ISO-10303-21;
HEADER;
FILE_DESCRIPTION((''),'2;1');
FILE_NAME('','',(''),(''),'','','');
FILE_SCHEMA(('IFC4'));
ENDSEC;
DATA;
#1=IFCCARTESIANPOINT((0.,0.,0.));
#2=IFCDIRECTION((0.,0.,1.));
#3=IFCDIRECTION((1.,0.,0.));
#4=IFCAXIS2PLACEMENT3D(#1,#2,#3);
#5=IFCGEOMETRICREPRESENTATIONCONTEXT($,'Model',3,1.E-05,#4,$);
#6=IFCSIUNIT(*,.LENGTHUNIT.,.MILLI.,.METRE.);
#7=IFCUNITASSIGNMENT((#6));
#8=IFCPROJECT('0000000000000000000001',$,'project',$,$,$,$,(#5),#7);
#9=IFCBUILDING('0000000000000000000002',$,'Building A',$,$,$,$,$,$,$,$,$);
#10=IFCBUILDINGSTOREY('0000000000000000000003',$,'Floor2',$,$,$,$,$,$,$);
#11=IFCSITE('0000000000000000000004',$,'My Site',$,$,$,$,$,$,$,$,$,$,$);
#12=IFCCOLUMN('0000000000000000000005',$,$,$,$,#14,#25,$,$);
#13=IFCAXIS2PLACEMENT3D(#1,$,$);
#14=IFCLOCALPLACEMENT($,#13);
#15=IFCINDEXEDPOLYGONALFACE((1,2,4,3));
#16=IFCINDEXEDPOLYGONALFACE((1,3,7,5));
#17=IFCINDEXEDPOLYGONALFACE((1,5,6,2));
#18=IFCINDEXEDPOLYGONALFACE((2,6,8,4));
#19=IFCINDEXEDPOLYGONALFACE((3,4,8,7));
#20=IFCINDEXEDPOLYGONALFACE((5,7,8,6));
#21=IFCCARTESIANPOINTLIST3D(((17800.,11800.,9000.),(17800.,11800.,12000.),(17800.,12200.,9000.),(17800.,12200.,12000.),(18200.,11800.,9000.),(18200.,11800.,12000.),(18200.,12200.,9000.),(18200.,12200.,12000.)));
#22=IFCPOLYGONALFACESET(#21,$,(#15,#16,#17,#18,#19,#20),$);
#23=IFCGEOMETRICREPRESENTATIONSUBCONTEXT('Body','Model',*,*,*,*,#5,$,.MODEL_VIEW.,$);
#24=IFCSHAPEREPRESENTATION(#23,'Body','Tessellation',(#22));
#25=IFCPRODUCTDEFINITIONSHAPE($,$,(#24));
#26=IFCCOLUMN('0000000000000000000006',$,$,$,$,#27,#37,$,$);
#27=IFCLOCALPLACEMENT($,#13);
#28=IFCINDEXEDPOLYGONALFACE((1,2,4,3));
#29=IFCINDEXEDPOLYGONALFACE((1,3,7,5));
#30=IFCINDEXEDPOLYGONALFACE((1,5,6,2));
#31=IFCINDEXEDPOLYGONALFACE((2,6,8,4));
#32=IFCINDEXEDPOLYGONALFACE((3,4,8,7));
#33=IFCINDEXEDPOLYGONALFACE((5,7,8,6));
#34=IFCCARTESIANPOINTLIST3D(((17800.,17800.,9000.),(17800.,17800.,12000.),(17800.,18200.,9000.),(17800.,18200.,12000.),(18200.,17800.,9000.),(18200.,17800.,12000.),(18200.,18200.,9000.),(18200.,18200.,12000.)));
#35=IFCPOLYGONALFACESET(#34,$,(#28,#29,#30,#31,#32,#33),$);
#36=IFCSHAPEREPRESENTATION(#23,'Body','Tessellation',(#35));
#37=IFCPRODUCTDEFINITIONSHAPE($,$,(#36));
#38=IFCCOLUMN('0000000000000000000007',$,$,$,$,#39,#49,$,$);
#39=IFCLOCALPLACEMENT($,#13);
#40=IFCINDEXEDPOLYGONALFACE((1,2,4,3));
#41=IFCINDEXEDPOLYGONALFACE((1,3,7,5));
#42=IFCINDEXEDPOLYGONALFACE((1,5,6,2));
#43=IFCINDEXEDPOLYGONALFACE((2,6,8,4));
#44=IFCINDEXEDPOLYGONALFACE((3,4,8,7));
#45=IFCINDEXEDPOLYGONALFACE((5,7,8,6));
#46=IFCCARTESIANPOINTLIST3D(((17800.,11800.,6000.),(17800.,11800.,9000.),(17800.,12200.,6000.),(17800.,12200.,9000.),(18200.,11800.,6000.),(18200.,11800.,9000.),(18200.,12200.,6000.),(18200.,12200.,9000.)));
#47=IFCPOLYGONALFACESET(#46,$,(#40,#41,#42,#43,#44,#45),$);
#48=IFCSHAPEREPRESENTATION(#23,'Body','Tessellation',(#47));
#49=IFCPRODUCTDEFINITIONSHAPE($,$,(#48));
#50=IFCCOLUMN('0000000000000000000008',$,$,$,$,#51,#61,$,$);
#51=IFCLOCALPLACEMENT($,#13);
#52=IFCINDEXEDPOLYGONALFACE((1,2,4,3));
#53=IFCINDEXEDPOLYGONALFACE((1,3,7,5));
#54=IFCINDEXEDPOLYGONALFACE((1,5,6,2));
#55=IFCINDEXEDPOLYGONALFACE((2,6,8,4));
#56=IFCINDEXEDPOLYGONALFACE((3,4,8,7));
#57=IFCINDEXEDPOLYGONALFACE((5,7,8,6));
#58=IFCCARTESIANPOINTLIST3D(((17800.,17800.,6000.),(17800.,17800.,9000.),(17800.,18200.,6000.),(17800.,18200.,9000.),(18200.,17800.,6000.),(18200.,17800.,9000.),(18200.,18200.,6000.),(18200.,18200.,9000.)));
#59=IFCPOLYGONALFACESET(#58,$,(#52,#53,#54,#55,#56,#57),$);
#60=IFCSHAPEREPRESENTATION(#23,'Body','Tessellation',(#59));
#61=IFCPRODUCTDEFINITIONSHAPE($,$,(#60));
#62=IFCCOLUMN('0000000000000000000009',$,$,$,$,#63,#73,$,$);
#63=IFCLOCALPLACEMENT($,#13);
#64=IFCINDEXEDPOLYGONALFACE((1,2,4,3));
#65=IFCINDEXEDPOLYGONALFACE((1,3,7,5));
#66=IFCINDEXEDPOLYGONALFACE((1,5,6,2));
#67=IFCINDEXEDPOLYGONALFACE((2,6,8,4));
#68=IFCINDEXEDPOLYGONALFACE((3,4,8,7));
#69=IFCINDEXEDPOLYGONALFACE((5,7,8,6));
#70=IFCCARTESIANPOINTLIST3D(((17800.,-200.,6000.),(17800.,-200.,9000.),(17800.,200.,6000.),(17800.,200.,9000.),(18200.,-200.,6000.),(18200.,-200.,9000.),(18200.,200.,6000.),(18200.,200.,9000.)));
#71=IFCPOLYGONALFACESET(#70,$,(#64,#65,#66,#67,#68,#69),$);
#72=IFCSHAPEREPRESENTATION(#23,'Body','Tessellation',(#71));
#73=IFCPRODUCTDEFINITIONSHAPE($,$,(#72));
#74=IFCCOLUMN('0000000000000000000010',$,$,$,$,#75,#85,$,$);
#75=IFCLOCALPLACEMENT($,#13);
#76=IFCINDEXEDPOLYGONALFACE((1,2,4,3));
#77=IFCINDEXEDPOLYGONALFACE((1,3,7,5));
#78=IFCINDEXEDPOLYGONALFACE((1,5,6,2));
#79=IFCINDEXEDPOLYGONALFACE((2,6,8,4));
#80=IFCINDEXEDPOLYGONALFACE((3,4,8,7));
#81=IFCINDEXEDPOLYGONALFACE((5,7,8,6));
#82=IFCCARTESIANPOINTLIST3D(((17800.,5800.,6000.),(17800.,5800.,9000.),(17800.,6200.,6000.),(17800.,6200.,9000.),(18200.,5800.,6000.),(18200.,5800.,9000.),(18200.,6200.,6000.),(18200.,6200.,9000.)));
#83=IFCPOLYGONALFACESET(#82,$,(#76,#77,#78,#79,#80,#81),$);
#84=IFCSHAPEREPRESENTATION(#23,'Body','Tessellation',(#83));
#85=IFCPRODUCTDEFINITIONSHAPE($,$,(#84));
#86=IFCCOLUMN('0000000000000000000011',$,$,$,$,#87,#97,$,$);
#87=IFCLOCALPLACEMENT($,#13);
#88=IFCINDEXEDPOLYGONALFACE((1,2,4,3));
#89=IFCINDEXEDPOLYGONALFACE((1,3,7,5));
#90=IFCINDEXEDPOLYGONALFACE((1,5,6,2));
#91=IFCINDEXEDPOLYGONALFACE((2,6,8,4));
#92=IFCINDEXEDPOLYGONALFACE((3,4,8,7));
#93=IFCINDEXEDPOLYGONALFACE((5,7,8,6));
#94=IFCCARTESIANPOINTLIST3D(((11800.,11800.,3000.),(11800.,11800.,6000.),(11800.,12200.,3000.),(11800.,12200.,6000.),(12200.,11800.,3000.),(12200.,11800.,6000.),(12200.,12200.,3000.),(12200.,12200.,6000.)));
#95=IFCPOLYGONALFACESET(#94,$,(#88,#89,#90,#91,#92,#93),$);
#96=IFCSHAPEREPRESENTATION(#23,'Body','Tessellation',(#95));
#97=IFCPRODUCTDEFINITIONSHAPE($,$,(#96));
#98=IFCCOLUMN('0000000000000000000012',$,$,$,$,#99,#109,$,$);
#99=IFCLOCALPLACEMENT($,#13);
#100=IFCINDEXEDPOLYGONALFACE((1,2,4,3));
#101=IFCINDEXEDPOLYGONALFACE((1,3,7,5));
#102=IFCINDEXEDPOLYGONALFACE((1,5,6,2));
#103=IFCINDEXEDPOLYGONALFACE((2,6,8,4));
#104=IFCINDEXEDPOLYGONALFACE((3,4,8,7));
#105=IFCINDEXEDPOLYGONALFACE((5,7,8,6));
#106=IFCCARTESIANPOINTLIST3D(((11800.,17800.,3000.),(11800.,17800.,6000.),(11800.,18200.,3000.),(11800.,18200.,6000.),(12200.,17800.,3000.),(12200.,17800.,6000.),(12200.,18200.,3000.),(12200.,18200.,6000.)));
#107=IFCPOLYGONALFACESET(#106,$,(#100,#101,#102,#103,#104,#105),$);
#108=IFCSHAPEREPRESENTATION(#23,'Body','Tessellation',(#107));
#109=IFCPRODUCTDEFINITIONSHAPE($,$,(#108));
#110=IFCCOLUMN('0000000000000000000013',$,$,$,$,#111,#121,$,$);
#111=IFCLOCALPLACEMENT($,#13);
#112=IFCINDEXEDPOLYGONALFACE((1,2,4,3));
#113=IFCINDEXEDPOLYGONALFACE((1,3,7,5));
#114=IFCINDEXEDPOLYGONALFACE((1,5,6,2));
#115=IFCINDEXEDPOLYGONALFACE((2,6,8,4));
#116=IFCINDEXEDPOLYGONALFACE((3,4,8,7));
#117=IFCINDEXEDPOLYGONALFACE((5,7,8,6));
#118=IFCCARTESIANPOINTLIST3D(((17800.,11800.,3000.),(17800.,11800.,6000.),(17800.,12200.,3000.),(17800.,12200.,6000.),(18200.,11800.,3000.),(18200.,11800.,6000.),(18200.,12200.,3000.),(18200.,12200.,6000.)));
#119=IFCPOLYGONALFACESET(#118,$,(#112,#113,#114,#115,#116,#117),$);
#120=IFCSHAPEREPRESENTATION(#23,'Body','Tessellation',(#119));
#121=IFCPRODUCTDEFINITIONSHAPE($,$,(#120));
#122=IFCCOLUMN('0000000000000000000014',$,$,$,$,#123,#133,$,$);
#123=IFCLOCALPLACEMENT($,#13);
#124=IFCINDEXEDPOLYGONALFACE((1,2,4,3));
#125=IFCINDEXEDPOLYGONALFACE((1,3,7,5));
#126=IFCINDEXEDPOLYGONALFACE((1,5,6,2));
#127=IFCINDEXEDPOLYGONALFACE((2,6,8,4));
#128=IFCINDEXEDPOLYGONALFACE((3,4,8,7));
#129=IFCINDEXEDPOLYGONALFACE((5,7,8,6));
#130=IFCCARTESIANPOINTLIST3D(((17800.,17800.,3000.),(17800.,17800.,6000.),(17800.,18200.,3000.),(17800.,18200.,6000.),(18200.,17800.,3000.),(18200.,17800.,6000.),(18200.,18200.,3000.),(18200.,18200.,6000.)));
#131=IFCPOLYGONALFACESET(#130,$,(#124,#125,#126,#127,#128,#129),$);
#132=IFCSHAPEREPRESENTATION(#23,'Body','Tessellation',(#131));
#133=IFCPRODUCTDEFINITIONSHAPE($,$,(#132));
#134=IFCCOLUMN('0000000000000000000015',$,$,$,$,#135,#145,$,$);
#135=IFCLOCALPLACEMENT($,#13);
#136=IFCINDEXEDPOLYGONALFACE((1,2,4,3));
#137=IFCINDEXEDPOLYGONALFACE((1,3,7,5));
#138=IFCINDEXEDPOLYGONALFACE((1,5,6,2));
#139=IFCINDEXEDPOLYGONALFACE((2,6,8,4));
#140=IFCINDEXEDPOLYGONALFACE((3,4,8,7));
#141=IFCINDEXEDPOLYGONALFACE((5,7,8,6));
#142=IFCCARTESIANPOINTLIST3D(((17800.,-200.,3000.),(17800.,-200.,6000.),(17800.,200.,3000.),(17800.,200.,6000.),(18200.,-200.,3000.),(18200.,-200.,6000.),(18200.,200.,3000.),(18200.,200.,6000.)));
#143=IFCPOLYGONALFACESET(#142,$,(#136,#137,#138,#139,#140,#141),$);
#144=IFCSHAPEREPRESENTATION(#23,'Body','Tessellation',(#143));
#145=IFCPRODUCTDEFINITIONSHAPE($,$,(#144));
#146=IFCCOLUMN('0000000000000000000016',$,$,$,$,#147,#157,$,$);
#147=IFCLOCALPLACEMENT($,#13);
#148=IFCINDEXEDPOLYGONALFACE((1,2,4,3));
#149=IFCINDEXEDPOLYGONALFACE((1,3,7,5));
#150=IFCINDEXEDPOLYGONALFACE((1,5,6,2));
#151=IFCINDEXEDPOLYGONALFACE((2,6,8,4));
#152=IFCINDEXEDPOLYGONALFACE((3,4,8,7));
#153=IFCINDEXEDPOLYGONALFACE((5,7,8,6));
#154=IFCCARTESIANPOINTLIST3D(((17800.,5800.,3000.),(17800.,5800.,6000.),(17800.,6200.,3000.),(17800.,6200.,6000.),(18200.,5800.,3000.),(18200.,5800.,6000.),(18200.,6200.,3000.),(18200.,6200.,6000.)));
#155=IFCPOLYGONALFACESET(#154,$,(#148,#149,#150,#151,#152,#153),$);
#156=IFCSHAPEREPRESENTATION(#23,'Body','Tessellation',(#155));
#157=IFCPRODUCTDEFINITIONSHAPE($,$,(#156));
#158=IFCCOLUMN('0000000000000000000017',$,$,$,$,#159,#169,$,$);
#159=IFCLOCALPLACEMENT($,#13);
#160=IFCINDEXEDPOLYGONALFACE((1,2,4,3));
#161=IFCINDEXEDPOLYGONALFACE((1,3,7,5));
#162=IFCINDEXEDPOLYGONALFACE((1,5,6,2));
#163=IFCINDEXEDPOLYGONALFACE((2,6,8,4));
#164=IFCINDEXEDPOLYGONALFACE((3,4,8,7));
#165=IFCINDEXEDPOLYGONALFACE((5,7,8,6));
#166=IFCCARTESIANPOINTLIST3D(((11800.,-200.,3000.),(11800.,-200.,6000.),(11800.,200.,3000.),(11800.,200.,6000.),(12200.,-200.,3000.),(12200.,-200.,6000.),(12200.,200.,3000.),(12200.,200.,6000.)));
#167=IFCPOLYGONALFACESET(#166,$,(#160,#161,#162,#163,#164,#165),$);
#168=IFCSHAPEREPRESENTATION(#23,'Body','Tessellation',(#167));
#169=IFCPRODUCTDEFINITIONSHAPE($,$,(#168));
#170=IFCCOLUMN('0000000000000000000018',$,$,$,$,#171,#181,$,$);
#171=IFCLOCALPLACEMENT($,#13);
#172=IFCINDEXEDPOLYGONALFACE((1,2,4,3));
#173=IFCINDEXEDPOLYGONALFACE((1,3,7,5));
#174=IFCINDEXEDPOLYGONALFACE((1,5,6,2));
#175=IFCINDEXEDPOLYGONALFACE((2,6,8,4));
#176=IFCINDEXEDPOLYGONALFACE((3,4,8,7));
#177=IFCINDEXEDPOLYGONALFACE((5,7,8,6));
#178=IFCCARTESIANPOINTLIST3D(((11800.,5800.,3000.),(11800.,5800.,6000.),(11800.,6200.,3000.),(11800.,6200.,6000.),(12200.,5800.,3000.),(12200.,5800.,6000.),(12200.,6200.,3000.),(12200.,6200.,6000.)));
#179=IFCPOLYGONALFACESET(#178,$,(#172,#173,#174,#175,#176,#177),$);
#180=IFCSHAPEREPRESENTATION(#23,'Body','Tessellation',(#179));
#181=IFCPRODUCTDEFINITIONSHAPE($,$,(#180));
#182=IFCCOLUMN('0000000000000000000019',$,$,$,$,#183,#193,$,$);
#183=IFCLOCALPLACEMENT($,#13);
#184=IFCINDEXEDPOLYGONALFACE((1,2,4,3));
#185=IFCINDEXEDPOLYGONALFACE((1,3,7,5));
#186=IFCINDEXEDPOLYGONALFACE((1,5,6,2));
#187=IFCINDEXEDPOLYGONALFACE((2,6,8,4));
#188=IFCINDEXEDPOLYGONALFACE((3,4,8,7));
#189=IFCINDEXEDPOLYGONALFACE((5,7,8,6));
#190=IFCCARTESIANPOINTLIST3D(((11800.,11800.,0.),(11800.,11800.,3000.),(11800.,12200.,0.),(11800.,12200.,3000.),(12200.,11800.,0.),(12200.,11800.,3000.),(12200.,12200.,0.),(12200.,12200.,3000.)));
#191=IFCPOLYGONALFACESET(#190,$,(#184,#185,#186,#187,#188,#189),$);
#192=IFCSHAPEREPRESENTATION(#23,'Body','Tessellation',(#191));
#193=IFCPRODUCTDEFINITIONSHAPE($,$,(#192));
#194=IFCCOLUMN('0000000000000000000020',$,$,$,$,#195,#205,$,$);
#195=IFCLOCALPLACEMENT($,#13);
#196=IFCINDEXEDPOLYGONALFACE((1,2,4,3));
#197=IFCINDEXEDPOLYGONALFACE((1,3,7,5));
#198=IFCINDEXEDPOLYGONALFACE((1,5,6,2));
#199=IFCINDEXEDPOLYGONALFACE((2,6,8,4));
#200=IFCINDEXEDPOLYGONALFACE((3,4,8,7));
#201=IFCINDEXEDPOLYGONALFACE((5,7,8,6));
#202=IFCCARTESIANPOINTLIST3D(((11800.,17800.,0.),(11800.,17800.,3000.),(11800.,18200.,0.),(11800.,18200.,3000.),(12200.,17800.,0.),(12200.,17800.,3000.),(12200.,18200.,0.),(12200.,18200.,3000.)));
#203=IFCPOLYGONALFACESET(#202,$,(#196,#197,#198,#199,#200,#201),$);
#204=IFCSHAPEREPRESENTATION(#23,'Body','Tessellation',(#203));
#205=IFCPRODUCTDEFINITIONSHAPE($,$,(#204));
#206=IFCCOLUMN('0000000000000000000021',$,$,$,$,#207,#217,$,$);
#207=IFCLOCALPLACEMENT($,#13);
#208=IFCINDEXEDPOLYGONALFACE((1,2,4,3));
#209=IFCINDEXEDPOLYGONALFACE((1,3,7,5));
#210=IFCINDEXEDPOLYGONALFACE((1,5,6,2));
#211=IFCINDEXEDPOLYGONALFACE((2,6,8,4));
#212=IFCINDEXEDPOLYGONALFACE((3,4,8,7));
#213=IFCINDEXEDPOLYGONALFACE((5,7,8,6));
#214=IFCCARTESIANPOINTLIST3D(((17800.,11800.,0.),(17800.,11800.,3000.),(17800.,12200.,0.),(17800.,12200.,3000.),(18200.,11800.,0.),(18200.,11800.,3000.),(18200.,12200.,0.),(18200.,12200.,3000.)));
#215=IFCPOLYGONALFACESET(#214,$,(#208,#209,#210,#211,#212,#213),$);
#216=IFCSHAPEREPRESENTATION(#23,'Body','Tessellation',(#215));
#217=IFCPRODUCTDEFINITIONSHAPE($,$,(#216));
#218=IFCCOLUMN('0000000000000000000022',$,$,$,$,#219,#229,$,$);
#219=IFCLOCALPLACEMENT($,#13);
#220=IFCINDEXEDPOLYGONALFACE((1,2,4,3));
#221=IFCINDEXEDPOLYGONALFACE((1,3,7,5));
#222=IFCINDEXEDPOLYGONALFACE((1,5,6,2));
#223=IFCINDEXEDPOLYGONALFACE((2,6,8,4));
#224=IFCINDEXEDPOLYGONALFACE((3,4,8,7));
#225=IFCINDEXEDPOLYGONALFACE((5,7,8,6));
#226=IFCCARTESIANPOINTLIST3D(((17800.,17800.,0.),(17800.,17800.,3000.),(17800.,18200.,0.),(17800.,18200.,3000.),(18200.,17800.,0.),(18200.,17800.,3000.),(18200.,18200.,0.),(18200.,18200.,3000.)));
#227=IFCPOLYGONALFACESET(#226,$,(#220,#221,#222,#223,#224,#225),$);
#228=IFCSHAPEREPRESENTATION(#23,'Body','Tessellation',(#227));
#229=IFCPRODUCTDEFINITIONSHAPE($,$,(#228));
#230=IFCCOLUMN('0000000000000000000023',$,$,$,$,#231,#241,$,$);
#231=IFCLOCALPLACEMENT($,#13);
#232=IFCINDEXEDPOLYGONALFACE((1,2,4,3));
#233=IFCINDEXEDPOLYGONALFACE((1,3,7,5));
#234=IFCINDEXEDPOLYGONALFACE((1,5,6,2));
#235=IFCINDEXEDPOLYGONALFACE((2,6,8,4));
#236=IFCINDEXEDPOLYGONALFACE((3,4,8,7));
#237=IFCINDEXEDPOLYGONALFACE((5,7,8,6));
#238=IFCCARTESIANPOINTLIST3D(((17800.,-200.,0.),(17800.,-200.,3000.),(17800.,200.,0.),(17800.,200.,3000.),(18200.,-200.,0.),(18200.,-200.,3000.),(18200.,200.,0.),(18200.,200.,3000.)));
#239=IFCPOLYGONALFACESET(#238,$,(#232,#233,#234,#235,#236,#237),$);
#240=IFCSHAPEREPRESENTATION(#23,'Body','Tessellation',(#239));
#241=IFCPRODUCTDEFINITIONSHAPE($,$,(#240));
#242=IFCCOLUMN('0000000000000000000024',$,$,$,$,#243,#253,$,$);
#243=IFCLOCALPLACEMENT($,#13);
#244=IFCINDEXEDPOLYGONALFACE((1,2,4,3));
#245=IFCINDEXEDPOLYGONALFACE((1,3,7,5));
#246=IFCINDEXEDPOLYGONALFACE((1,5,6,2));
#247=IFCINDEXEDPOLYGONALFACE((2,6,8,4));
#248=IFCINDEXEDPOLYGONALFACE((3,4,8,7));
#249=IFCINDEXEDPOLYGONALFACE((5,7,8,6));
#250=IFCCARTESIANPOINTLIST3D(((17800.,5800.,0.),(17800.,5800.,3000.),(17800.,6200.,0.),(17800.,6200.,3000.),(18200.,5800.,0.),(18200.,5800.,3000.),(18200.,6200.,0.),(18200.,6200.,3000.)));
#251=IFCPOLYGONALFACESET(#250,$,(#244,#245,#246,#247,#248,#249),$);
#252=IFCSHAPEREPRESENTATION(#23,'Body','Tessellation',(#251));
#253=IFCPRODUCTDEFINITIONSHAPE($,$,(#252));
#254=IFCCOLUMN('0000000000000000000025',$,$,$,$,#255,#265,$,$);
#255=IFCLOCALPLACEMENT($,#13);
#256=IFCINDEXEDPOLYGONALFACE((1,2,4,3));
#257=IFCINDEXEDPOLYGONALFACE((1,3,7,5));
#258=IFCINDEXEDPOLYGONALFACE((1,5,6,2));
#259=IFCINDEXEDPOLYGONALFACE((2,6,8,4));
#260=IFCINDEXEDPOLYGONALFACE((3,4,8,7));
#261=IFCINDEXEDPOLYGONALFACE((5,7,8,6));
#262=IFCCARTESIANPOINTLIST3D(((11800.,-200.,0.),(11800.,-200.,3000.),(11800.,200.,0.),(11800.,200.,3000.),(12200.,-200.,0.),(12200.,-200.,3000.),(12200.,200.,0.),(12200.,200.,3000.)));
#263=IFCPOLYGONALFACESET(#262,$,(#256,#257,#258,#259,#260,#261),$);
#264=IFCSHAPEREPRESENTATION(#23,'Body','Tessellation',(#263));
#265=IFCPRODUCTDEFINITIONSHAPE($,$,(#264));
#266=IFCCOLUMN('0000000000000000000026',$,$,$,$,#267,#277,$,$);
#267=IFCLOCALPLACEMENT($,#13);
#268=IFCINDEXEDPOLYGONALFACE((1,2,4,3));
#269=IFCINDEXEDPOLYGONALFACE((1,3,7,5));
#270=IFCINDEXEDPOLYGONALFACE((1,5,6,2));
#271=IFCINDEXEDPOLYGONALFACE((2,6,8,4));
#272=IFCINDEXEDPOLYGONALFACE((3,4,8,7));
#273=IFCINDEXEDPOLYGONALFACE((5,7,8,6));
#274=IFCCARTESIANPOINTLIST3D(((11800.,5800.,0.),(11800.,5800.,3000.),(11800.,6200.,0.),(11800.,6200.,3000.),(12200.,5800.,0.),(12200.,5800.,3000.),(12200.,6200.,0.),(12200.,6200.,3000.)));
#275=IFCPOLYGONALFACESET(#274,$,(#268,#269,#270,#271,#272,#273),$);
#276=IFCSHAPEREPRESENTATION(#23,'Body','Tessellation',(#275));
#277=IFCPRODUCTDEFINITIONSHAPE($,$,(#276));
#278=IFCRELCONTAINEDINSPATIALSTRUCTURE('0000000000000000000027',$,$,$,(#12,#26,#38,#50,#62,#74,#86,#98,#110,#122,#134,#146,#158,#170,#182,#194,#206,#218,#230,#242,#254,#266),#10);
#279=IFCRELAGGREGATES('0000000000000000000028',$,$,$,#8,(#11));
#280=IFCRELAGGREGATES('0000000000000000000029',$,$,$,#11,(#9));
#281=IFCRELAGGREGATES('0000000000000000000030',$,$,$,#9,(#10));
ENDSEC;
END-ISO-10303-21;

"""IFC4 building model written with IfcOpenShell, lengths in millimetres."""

from ifc_helpers import new_model, si_unit, frame, origin_with_axes, place, context, subcontext, project, spatial, line, indexed_curve, outline, extrude, element, save


model = new_model("IFC4")

# Units and contexts
model_context = context("Model", 3, precision=1e-05, world=origin_with_axes())
body_context = subcontext(model_context, "Body", "Model", "MODEL_VIEW")
ifc_project = project(units=[si_unit("LENGTHUNIT", "METRE", prefix="MILLI")], contexts=[model_context])

# Site, building, storey
site = spatial("IfcSite", under=ifc_project, Name="My Site")
building = spatial("IfcBuilding", under=site, Name="Building A")
storey = spatial("IfcBuildingStorey", under=building, Name="Floor2")

# Columns
for number, where, z_axis, x_axis in (
    (1, (18000.0, 12000.0, 9000.0), (0.0, 0.0, 1.0), (1.0, 0.0, 0.0)),
    (2, (18000.0, 18000.0, 9000.0), (0.0, 0.0, 1.0), (1.0, 0.0, 0.0)),
    (3, (18000.0, 12000.0, 6000.0), (0.0, 0.0, 1.0), (1.0, 0.0, 0.0)),
    (4, (18000.0, 18000.0, 6000.0), (0.0, 0.0, 1.0), (1.0, 0.0, 0.0)),
    (5, (18000.0, 0.0, 6000.0), (0.0, 0.0, 1.0), (1.0, 0.0, 0.0)),
    (6, (18000.0, 6000.0, 6000.0), (0.0, 0.0, 1.0), (1.0, 0.0, 0.0)),
    (7, (12000.0, 12000.0, 3000.0), (0.0, 0.0, 1.0), (1.0, 0.0, 0.0)),
    (8, (12000.0, 18000.0, 3000.0), (0.0, 0.0, 1.0), (1.0, 0.0, 0.0)),
    (9, (18000.0, 12000.0, 3000.0), (0.0, 0.0, 1.0), (1.0, 0.0, 0.0)),
    (10, (18000.0, 18000.0, 3000.0), (0.0, 0.0, 1.0), (1.0, 0.0, 0.0)),
    (11, (18000.0, 0.0, 3000.0), (0.0, 0.0, 1.0), (1.0, 0.0, 0.0)),
    (12, (18000.0, 6000.0, 3000.0), (0.0, 0.0, 1.0), (1.0, 0.0, 0.0)),
    (13, (12000.0, 0.0, 3000.0), (0.0, 0.0, 1.0), (1.0, 0.0, 0.0)),
    (14, (12000.0, 6000.0, 3000.0), (0.0, 0.0, 1.0), (1.0, 0.0, 0.0)),
    (15, (12000.0, 12000.0, 0.0), (0.0, 0.0, 1.0), (1.0, 0.0, 0.0)),
    (16, (12000.0, 18000.0, 0.0), (0.0, 0.0, 1.0), (1.0, 0.0, 0.0)),
    (17, (18000.0, 12000.0, 0.0), (0.0, 0.0, 1.0), (1.0, 0.0, 0.0)),
    (18, (18000.0, 18000.0, 0.0), (0.0, 0.0, 1.0), (1.0, 0.0, 0.0)),
    (19, (18000.0, 0.0, 0.0), (0.0, 0.0, 1.0), (1.0, 0.0, 0.0)),
    (20, (18000.0, 6000.0, 0.0), (0.0, 0.0, 1.0), (1.0, 0.0, 0.0)),
    (21, (12000.0, 0.0, 0.0), (0.0, 0.0, 1.0), (1.0, 0.0, 0.0)),
    (22, (12000.0, 6000.0, 0.0), (0.0, 0.0, 1.0), (1.0, 0.0, 0.0)),
):
    element("IfcColumn", number, at=place(None, frame(where, z_axis=z_axis, x_axis=x_axis)), inside=storey, context=body_context, shape_type="SweptSolid", body=[
        extrude(outline(indexed_curve([(-200.0, -200.0), (200.0, -200.0), (200.0, 200.0), (-200.0, 200.0)], segments=[line(1, 2, 3, 4, 1)])), origin_with_axes(), (0.0, 0.0, 1.0), 3000.0),
    ])

save(model, "model.ifc")
